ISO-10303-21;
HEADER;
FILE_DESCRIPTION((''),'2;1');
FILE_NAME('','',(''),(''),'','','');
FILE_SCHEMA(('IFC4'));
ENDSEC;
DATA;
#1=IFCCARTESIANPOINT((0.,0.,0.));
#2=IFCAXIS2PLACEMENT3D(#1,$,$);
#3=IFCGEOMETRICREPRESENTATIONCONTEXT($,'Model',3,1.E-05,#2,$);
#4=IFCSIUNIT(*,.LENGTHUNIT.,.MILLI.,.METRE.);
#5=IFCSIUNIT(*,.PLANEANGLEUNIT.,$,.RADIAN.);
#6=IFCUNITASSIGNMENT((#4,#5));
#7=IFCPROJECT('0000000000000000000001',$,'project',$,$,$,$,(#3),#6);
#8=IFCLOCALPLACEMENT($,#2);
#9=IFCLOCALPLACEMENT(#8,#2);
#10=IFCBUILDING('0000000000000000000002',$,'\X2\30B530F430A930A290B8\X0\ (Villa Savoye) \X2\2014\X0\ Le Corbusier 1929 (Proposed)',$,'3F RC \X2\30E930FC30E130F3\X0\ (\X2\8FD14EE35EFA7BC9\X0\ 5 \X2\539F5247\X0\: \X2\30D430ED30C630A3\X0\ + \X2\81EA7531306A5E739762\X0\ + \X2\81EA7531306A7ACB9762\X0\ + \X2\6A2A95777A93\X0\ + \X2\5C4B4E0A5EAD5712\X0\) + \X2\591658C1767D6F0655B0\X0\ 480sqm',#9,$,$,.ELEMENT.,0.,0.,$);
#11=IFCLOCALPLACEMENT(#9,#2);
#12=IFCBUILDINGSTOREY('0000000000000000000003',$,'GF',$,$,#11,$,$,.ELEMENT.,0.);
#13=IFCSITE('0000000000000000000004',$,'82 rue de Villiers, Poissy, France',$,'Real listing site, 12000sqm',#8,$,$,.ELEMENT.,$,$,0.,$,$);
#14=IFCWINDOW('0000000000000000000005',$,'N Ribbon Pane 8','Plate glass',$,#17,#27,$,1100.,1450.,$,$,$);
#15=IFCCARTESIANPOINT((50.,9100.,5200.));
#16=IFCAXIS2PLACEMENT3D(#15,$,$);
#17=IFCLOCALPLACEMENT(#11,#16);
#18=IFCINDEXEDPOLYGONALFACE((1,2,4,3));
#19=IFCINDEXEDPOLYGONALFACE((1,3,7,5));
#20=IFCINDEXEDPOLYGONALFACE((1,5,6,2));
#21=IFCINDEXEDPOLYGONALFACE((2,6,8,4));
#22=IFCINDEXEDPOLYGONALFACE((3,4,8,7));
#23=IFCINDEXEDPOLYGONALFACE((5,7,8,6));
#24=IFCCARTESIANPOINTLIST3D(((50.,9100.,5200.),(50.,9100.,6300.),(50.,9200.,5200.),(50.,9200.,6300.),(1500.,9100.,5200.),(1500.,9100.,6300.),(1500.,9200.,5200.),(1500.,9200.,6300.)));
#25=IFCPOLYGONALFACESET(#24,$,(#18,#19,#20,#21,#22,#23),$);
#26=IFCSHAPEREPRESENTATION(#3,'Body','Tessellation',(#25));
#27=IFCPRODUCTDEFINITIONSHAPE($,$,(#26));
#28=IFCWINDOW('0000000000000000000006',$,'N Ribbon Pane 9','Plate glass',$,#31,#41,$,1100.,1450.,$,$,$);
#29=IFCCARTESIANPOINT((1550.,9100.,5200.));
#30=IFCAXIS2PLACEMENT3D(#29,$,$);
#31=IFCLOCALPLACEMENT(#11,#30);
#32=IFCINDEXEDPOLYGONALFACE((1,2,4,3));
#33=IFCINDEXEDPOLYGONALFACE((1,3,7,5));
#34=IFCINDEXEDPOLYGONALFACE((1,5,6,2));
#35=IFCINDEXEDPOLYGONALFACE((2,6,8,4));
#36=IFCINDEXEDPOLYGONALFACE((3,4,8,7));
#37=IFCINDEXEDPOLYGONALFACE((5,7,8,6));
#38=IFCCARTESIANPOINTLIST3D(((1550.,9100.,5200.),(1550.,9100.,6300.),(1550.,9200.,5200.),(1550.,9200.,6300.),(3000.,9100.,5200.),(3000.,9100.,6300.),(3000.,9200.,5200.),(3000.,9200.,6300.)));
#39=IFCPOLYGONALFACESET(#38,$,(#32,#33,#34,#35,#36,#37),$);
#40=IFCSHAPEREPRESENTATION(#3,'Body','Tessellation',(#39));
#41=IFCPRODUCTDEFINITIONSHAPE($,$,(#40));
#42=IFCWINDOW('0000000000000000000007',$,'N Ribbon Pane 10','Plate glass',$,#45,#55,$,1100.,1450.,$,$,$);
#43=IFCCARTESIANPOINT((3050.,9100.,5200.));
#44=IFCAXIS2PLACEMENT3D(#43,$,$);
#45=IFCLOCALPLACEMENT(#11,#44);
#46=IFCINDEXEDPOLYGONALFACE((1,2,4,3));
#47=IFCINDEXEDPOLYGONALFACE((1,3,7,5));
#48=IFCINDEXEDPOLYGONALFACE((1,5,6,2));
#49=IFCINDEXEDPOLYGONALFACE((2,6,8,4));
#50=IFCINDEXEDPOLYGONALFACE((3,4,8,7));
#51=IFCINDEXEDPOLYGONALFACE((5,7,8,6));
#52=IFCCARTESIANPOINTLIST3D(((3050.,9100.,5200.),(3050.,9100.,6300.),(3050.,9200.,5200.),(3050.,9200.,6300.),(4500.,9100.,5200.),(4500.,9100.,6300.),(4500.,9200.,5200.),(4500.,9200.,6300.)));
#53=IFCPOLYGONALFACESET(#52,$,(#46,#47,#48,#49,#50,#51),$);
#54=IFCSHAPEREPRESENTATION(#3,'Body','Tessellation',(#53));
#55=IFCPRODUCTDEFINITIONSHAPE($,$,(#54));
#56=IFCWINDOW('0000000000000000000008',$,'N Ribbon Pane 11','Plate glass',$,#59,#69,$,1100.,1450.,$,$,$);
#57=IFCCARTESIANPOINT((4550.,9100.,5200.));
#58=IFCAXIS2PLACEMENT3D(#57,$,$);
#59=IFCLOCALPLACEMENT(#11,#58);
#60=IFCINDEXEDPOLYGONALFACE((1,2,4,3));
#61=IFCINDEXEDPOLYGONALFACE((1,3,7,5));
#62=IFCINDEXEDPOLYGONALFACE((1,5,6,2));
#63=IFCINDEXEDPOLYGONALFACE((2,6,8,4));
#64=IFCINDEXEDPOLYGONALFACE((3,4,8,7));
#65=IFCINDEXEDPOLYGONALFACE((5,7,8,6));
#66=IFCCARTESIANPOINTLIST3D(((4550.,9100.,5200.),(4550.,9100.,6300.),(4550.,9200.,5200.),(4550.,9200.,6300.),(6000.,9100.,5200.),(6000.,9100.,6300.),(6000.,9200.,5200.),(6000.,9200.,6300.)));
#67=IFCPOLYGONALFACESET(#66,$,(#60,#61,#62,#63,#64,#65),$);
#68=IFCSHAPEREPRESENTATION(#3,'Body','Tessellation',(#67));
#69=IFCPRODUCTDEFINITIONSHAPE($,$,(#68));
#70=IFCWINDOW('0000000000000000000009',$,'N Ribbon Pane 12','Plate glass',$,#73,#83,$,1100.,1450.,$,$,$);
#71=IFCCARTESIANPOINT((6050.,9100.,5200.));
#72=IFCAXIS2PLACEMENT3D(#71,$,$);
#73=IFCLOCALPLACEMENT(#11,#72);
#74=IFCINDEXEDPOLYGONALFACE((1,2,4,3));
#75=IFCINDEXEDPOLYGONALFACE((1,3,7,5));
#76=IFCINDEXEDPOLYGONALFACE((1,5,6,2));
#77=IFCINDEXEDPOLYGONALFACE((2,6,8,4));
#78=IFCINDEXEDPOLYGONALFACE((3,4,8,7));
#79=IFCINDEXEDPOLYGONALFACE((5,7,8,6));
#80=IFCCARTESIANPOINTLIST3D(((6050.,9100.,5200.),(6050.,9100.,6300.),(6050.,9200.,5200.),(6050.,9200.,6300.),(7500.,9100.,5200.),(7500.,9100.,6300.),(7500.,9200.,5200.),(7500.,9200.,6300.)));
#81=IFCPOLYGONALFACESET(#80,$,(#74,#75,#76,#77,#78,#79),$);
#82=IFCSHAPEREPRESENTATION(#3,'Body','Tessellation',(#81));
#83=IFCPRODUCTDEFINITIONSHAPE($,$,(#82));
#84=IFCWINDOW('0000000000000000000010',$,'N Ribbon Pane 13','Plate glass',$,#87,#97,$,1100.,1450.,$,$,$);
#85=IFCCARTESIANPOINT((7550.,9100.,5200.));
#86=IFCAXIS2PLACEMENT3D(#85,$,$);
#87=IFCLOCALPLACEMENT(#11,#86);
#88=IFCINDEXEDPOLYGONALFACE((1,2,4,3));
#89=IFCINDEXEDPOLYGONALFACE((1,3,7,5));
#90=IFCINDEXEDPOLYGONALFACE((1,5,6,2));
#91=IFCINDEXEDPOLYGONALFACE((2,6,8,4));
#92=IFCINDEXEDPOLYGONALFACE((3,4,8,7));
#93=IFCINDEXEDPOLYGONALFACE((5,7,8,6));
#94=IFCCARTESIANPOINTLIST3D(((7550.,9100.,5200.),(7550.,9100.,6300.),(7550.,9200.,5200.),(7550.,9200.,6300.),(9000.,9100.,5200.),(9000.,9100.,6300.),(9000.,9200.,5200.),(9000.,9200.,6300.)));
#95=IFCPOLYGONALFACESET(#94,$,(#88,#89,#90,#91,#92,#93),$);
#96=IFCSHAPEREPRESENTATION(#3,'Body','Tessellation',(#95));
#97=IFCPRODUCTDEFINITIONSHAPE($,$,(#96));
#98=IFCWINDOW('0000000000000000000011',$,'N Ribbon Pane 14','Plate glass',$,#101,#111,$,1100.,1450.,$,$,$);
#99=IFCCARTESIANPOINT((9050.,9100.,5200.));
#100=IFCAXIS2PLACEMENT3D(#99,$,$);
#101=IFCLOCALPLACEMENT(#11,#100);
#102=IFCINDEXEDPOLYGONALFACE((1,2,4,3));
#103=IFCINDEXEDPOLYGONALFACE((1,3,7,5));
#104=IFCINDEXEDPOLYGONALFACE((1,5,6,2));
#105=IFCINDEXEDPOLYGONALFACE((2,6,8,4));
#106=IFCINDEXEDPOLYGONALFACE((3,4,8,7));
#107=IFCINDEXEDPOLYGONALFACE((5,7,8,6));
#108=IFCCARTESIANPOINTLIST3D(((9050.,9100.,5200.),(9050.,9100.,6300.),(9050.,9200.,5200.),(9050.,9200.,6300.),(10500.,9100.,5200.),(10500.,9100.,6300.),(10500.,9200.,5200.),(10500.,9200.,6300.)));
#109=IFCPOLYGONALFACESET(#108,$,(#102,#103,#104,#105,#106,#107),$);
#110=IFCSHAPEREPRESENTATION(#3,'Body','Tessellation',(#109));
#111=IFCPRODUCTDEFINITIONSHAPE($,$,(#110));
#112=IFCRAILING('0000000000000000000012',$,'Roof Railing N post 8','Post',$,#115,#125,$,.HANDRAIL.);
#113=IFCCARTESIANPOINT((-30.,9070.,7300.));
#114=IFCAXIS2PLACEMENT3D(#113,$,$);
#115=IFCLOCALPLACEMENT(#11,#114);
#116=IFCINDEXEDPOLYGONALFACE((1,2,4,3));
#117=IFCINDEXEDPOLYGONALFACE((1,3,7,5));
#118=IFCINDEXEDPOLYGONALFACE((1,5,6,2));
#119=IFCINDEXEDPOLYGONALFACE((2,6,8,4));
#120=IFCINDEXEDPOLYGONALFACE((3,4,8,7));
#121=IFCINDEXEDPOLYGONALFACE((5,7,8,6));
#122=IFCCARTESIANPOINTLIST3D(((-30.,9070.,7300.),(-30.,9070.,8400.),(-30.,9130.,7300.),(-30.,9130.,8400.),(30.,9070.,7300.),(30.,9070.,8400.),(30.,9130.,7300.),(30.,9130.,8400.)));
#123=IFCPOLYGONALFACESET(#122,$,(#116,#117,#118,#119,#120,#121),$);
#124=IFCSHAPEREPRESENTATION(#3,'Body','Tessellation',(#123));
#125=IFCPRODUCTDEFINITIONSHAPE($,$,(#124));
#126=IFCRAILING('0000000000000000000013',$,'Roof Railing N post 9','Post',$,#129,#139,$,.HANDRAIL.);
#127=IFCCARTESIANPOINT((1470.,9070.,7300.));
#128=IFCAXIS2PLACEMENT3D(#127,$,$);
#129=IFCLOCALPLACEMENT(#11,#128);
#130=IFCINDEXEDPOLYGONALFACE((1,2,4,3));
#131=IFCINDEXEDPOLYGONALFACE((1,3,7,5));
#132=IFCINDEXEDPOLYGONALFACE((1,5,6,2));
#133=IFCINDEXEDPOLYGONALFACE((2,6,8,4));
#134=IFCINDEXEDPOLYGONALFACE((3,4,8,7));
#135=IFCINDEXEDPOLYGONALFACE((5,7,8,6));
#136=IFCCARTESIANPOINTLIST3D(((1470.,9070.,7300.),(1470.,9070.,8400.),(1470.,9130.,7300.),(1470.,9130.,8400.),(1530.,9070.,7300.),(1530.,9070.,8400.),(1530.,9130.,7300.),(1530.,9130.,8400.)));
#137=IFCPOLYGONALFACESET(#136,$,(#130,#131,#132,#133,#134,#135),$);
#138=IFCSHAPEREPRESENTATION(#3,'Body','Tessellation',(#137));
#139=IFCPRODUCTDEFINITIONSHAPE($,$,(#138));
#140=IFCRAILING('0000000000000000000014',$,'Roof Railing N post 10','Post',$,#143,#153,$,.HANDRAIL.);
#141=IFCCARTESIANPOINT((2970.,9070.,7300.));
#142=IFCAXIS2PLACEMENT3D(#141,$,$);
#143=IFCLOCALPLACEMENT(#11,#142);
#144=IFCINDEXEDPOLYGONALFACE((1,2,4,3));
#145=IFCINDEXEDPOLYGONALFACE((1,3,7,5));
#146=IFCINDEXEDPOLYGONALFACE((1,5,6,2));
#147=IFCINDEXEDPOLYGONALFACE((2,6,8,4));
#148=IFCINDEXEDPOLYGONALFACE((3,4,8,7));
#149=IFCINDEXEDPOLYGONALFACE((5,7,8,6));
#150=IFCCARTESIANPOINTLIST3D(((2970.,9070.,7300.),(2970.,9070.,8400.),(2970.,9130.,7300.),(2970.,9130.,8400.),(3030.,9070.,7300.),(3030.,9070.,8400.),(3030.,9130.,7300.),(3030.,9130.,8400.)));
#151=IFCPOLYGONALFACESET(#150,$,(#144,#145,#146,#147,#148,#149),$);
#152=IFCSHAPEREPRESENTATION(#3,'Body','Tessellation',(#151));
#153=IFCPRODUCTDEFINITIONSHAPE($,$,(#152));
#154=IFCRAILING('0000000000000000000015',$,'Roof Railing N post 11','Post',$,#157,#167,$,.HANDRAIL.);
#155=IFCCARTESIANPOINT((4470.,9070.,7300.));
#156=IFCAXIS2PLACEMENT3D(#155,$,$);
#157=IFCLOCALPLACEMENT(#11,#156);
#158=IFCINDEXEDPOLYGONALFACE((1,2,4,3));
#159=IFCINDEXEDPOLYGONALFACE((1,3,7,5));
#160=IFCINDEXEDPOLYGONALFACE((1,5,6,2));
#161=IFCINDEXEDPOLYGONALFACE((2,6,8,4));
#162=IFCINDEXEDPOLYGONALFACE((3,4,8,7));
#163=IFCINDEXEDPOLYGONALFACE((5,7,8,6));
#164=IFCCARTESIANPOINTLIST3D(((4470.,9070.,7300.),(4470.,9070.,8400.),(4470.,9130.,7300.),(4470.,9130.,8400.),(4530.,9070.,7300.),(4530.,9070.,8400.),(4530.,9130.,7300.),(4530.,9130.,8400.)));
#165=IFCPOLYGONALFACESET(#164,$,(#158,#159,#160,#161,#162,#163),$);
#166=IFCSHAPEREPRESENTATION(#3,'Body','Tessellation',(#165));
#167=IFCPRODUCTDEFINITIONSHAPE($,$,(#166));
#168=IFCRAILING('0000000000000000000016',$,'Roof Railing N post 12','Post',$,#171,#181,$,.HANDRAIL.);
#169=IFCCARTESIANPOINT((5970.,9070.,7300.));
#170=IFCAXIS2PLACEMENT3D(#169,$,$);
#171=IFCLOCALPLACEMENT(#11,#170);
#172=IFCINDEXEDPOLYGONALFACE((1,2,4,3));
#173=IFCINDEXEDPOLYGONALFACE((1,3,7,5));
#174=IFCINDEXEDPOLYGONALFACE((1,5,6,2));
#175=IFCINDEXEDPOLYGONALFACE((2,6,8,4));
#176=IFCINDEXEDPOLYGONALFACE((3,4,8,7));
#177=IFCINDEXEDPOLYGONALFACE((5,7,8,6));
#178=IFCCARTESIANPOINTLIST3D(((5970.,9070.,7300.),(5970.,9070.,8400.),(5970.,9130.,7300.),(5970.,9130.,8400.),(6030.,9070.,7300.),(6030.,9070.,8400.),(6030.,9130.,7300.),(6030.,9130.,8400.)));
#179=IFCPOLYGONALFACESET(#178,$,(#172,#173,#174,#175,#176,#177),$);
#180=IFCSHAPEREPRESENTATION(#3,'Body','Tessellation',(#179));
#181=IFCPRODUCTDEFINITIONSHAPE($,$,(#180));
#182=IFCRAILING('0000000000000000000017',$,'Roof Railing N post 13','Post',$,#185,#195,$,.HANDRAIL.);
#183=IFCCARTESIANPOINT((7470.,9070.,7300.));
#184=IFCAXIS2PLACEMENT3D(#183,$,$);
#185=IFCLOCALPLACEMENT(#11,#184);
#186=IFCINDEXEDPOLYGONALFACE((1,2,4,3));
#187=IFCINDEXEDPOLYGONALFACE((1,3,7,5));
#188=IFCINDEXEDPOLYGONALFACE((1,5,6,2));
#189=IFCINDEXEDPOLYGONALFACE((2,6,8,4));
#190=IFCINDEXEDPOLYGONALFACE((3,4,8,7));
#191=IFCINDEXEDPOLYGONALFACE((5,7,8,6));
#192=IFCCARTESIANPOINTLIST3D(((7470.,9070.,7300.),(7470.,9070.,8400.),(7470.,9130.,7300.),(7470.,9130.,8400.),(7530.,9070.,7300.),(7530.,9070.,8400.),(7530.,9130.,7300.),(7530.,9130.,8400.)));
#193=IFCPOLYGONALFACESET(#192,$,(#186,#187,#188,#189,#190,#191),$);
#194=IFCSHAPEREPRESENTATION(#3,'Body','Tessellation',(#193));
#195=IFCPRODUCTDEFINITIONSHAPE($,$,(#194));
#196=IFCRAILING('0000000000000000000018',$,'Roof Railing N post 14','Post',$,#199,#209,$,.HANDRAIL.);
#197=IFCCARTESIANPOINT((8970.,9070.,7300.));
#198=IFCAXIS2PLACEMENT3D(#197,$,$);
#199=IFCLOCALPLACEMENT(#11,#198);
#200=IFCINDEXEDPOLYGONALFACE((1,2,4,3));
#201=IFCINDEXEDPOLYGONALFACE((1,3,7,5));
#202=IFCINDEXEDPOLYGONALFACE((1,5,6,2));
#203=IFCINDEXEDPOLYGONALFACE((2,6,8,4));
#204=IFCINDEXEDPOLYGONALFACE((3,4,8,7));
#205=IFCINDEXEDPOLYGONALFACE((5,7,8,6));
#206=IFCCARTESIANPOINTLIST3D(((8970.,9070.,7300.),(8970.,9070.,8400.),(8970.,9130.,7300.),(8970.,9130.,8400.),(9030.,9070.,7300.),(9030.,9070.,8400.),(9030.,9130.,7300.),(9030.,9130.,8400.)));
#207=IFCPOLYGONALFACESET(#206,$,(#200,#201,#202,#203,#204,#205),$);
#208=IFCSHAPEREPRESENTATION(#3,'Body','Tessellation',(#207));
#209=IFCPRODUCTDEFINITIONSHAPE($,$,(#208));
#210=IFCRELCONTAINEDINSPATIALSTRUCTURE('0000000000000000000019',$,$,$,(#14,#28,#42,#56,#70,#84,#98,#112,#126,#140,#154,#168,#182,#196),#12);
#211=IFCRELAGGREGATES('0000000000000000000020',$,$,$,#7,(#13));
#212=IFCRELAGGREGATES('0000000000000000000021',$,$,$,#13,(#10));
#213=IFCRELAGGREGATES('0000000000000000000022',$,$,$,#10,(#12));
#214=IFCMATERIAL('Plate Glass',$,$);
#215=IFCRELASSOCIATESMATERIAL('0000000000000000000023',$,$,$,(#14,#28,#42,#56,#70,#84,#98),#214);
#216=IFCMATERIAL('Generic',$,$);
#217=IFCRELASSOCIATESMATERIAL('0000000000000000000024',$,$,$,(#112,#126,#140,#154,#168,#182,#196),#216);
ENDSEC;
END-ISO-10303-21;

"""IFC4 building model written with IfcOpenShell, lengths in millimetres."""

from ifc_helpers import new_model, si_unit, frame, frame_2d, origin, place, context, project, spatial, rectangle, extrude, material, element, save


model = new_model("IFC4")

# Units and contexts
model_context = context("Model", 3, precision=1e-05, world=origin())
ifc_project = project(units=[si_unit("LENGTHUNIT", "METRE", prefix="MILLI"), si_unit("PLANEANGLEUNIT", "RADIAN")], contexts=[model_context])

# Site, building, storey
site_placement = place(None, origin())
site = spatial("IfcSite", under=ifc_project, at=site_placement, Name="82 rue de Villiers, Poissy, France", ObjectType="Real listing site, 12000sqm", CompositionType="ELEMENT", RefElevation=0.0)
building_placement = place(site_placement, origin())
building = spatial("IfcBuilding", under=site, at=building_placement, Name="サヴォア邸 (Villa Savoye) — Le Corbusier 1929 (Proposed)", ObjectType="3F RC ラーメン (近代建築 5 原則: ピロティ + 自由な平面 + 自由な立面 + 横長窓 + 屋上庭園) + 外壁白漆喰 480sqm", CompositionType="ELEMENT", ElevationOfRefHeight=0.0, ElevationOfTerrain=0.0)
storey_placement = place(building_placement, origin())
storey = spatial("IfcBuildingStorey", under=building, at=storey_placement, Name="GF", CompositionType="ELEMENT", Elevation=0.0)

# Windows
ifc_material_1 = material(Name="Plate Glass")
window_1_placement = place(storey_placement, frame((50.0, 9100.0, 5200.0)))
element("IfcWindow", 1, at=window_1_placement, inside=storey, material=ifc_material_1, Name="N Ribbon Pane 8", Description="Plate glass", OverallHeight=1100.0, OverallWidth=1450.0, context=model_context, shape_type="SweptSolid", body=[
    extrude(rectangle(XDim=1450.0, YDim=100.0, at=frame_2d((725.0, 50.0))), frame((50.0, 9100.0, 5200.0)), (0.0, 0.0, 1.0), 1100.0),
])
window_2_placement = place(storey_placement, frame((1550.0, 9100.0, 5200.0)))
element("IfcWindow", 2, at=window_2_placement, inside=storey, material=ifc_material_1, Name="N Ribbon Pane 9", Description="Plate glass", OverallHeight=1100.0, OverallWidth=1450.0, context=model_context, shape_type="SweptSolid", body=[
    extrude(rectangle(XDim=1450.0, YDim=100.0, at=frame_2d((725.0, 50.0))), frame((1550.0, 9100.0, 5200.0)), (0.0, 0.0, 1.0), 1100.0),
])
window_3_placement = place(storey_placement, frame((3050.0, 9100.0, 5200.0)))
element("IfcWindow", 3, at=window_3_placement, inside=storey, material=ifc_material_1, Name="N Ribbon Pane 10", Description="Plate glass", OverallHeight=1100.0, OverallWidth=1450.0, context=model_context, shape_type="SweptSolid", body=[
    extrude(rectangle(XDim=1450.0, YDim=100.0, at=frame_2d((725.0, 50.0))), frame((3050.0, 9100.0, 5200.0)), (0.0, 0.0, 1.0), 1100.0),
])
window_4_placement = place(storey_placement, frame((4550.0, 9100.0, 5200.0)))
element("IfcWindow", 4, at=window_4_placement, inside=storey, material=ifc_material_1, Name="N Ribbon Pane 11", Description="Plate glass", OverallHeight=1100.0, OverallWidth=1450.0, context=model_context, shape_type="SweptSolid", body=[
    extrude(rectangle(XDim=1450.0, YDim=100.0, at=frame_2d((725.0, 50.0))), frame((4550.0, 9100.0, 5200.0)), (0.0, 0.0, 1.0), 1100.0),
])
window_5_placement = place(storey_placement, frame((6050.0, 9100.0, 5200.0)))
element("IfcWindow", 5, at=window_5_placement, inside=storey, material=ifc_material_1, Name="N Ribbon Pane 12", Description="Plate glass", OverallHeight=1100.0, OverallWidth=1450.0, context=model_context, shape_type="SweptSolid", body=[
    extrude(rectangle(XDim=1450.0, YDim=100.0, at=frame_2d((725.0, 50.0))), frame((6050.0, 9100.0, 5200.0)), (0.0, 0.0, 1.0), 1100.0),
])
window_6_placement = place(storey_placement, frame((7550.0, 9100.0, 5200.0)))
element("IfcWindow", 6, at=window_6_placement, inside=storey, material=ifc_material_1, Name="N Ribbon Pane 13", Description="Plate glass", OverallHeight=1100.0, OverallWidth=1450.0, context=model_context, shape_type="SweptSolid", body=[
    extrude(rectangle(XDim=1450.0, YDim=100.0, at=frame_2d((725.0, 50.0))), frame((7550.0, 9100.0, 5200.0)), (0.0, 0.0, 1.0), 1100.0),
])
window_7_placement = place(storey_placement, frame((9050.0, 9100.0, 5200.0)))
element("IfcWindow", 7, at=window_7_placement, inside=storey, material=ifc_material_1, Name="N Ribbon Pane 14", Description="Plate glass", OverallHeight=1100.0, OverallWidth=1450.0, context=model_context, shape_type="SweptSolid", body=[
    extrude(rectangle(XDim=1450.0, YDim=100.0, at=frame_2d((725.0, 50.0))), frame((9050.0, 9100.0, 5200.0)), (0.0, 0.0, 1.0), 1100.0),
])

# Railings
ifc_material_2 = material(Name="Generic")
railing_1_placement = place(storey_placement, frame((-30.0, 9070.0, 7300.0)))
element("IfcRailing", 8, at=railing_1_placement, inside=storey, material=ifc_material_2, Name="Roof Railing N post 8", Description="Post", PredefinedType="HANDRAIL", context=model_context, shape_type="SweptSolid", body=[
    extrude(rectangle(XDim=60.0, YDim=60.0, at=frame_2d((30.0, 30.0))), frame((-30.0, 9070.0, 7300.0)), (0.0, 0.0, 1.0), 1100.0),
])
railing_2_placement = place(storey_placement, frame((1470.0, 9070.0, 7300.0)))
element("IfcRailing", 9, at=railing_2_placement, inside=storey, material=ifc_material_2, Name="Roof Railing N post 9", Description="Post", PredefinedType="HANDRAIL", context=model_context, shape_type="SweptSolid", body=[
    extrude(rectangle(XDim=60.0, YDim=60.0, at=frame_2d((30.0, 30.0))), frame((1470.0, 9070.0, 7300.0)), (0.0, 0.0, 1.0), 1100.0),
])
railing_3_placement = place(storey_placement, frame((2970.0, 9070.0, 7300.0)))
element("IfcRailing", 10, at=railing_3_placement, inside=storey, material=ifc_material_2, Name="Roof Railing N post 10", Description="Post", PredefinedType="HANDRAIL", context=model_context, shape_type="SweptSolid", body=[
    extrude(rectangle(XDim=60.0, YDim=60.0, at=frame_2d((30.0, 30.0))), frame((2970.0, 9070.0, 7300.0)), (0.0, 0.0, 1.0), 1100.0),
])
railing_4_placement = place(storey_placement, frame((4470.0, 9070.0, 7300.0)))
element("IfcRailing", 11, at=railing_4_placement, inside=storey, material=ifc_material_2, Name="Roof Railing N post 11", Description="Post", PredefinedType="HANDRAIL", context=model_context, shape_type="SweptSolid", body=[
    extrude(rectangle(XDim=60.0, YDim=60.0, at=frame_2d((30.0, 30.0))), frame((4470.0, 9070.0, 7300.0)), (0.0, 0.0, 1.0), 1100.0),
])
railing_5_placement = place(storey_placement, frame((5970.0, 9070.0, 7300.0)))
element("IfcRailing", 12, at=railing_5_placement, inside=storey, material=ifc_material_2, Name="Roof Railing N post 12", Description="Post", PredefinedType="HANDRAIL", context=model_context, shape_type="SweptSolid", body=[
    extrude(rectangle(XDim=60.0, YDim=60.0, at=frame_2d((30.0, 30.0))), frame((5970.0, 9070.0, 7300.0)), (0.0, 0.0, 1.0), 1100.0),
])
railing_6_placement = place(storey_placement, frame((7470.0, 9070.0, 7300.0)))
element("IfcRailing", 13, at=railing_6_placement, inside=storey, material=ifc_material_2, Name="Roof Railing N post 13", Description="Post", PredefinedType="HANDRAIL", context=model_context, shape_type="SweptSolid", body=[
    extrude(rectangle(XDim=60.0, YDim=60.0, at=frame_2d((30.0, 30.0))), frame((7470.0, 9070.0, 7300.0)), (0.0, 0.0, 1.0), 1100.0),
])
railing_7_placement = place(storey_placement, frame((8970.0, 9070.0, 7300.0)))
element("IfcRailing", 14, at=railing_7_placement, inside=storey, material=ifc_material_2, Name="Roof Railing N post 14", Description="Post", PredefinedType="HANDRAIL", context=model_context, shape_type="SweptSolid", body=[
    extrude(rectangle(XDim=60.0, YDim=60.0, at=frame_2d((30.0, 30.0))), frame((8970.0, 9070.0, 7300.0)), (0.0, 0.0, 1.0), 1100.0),
])

save(model, "model.ifc")
